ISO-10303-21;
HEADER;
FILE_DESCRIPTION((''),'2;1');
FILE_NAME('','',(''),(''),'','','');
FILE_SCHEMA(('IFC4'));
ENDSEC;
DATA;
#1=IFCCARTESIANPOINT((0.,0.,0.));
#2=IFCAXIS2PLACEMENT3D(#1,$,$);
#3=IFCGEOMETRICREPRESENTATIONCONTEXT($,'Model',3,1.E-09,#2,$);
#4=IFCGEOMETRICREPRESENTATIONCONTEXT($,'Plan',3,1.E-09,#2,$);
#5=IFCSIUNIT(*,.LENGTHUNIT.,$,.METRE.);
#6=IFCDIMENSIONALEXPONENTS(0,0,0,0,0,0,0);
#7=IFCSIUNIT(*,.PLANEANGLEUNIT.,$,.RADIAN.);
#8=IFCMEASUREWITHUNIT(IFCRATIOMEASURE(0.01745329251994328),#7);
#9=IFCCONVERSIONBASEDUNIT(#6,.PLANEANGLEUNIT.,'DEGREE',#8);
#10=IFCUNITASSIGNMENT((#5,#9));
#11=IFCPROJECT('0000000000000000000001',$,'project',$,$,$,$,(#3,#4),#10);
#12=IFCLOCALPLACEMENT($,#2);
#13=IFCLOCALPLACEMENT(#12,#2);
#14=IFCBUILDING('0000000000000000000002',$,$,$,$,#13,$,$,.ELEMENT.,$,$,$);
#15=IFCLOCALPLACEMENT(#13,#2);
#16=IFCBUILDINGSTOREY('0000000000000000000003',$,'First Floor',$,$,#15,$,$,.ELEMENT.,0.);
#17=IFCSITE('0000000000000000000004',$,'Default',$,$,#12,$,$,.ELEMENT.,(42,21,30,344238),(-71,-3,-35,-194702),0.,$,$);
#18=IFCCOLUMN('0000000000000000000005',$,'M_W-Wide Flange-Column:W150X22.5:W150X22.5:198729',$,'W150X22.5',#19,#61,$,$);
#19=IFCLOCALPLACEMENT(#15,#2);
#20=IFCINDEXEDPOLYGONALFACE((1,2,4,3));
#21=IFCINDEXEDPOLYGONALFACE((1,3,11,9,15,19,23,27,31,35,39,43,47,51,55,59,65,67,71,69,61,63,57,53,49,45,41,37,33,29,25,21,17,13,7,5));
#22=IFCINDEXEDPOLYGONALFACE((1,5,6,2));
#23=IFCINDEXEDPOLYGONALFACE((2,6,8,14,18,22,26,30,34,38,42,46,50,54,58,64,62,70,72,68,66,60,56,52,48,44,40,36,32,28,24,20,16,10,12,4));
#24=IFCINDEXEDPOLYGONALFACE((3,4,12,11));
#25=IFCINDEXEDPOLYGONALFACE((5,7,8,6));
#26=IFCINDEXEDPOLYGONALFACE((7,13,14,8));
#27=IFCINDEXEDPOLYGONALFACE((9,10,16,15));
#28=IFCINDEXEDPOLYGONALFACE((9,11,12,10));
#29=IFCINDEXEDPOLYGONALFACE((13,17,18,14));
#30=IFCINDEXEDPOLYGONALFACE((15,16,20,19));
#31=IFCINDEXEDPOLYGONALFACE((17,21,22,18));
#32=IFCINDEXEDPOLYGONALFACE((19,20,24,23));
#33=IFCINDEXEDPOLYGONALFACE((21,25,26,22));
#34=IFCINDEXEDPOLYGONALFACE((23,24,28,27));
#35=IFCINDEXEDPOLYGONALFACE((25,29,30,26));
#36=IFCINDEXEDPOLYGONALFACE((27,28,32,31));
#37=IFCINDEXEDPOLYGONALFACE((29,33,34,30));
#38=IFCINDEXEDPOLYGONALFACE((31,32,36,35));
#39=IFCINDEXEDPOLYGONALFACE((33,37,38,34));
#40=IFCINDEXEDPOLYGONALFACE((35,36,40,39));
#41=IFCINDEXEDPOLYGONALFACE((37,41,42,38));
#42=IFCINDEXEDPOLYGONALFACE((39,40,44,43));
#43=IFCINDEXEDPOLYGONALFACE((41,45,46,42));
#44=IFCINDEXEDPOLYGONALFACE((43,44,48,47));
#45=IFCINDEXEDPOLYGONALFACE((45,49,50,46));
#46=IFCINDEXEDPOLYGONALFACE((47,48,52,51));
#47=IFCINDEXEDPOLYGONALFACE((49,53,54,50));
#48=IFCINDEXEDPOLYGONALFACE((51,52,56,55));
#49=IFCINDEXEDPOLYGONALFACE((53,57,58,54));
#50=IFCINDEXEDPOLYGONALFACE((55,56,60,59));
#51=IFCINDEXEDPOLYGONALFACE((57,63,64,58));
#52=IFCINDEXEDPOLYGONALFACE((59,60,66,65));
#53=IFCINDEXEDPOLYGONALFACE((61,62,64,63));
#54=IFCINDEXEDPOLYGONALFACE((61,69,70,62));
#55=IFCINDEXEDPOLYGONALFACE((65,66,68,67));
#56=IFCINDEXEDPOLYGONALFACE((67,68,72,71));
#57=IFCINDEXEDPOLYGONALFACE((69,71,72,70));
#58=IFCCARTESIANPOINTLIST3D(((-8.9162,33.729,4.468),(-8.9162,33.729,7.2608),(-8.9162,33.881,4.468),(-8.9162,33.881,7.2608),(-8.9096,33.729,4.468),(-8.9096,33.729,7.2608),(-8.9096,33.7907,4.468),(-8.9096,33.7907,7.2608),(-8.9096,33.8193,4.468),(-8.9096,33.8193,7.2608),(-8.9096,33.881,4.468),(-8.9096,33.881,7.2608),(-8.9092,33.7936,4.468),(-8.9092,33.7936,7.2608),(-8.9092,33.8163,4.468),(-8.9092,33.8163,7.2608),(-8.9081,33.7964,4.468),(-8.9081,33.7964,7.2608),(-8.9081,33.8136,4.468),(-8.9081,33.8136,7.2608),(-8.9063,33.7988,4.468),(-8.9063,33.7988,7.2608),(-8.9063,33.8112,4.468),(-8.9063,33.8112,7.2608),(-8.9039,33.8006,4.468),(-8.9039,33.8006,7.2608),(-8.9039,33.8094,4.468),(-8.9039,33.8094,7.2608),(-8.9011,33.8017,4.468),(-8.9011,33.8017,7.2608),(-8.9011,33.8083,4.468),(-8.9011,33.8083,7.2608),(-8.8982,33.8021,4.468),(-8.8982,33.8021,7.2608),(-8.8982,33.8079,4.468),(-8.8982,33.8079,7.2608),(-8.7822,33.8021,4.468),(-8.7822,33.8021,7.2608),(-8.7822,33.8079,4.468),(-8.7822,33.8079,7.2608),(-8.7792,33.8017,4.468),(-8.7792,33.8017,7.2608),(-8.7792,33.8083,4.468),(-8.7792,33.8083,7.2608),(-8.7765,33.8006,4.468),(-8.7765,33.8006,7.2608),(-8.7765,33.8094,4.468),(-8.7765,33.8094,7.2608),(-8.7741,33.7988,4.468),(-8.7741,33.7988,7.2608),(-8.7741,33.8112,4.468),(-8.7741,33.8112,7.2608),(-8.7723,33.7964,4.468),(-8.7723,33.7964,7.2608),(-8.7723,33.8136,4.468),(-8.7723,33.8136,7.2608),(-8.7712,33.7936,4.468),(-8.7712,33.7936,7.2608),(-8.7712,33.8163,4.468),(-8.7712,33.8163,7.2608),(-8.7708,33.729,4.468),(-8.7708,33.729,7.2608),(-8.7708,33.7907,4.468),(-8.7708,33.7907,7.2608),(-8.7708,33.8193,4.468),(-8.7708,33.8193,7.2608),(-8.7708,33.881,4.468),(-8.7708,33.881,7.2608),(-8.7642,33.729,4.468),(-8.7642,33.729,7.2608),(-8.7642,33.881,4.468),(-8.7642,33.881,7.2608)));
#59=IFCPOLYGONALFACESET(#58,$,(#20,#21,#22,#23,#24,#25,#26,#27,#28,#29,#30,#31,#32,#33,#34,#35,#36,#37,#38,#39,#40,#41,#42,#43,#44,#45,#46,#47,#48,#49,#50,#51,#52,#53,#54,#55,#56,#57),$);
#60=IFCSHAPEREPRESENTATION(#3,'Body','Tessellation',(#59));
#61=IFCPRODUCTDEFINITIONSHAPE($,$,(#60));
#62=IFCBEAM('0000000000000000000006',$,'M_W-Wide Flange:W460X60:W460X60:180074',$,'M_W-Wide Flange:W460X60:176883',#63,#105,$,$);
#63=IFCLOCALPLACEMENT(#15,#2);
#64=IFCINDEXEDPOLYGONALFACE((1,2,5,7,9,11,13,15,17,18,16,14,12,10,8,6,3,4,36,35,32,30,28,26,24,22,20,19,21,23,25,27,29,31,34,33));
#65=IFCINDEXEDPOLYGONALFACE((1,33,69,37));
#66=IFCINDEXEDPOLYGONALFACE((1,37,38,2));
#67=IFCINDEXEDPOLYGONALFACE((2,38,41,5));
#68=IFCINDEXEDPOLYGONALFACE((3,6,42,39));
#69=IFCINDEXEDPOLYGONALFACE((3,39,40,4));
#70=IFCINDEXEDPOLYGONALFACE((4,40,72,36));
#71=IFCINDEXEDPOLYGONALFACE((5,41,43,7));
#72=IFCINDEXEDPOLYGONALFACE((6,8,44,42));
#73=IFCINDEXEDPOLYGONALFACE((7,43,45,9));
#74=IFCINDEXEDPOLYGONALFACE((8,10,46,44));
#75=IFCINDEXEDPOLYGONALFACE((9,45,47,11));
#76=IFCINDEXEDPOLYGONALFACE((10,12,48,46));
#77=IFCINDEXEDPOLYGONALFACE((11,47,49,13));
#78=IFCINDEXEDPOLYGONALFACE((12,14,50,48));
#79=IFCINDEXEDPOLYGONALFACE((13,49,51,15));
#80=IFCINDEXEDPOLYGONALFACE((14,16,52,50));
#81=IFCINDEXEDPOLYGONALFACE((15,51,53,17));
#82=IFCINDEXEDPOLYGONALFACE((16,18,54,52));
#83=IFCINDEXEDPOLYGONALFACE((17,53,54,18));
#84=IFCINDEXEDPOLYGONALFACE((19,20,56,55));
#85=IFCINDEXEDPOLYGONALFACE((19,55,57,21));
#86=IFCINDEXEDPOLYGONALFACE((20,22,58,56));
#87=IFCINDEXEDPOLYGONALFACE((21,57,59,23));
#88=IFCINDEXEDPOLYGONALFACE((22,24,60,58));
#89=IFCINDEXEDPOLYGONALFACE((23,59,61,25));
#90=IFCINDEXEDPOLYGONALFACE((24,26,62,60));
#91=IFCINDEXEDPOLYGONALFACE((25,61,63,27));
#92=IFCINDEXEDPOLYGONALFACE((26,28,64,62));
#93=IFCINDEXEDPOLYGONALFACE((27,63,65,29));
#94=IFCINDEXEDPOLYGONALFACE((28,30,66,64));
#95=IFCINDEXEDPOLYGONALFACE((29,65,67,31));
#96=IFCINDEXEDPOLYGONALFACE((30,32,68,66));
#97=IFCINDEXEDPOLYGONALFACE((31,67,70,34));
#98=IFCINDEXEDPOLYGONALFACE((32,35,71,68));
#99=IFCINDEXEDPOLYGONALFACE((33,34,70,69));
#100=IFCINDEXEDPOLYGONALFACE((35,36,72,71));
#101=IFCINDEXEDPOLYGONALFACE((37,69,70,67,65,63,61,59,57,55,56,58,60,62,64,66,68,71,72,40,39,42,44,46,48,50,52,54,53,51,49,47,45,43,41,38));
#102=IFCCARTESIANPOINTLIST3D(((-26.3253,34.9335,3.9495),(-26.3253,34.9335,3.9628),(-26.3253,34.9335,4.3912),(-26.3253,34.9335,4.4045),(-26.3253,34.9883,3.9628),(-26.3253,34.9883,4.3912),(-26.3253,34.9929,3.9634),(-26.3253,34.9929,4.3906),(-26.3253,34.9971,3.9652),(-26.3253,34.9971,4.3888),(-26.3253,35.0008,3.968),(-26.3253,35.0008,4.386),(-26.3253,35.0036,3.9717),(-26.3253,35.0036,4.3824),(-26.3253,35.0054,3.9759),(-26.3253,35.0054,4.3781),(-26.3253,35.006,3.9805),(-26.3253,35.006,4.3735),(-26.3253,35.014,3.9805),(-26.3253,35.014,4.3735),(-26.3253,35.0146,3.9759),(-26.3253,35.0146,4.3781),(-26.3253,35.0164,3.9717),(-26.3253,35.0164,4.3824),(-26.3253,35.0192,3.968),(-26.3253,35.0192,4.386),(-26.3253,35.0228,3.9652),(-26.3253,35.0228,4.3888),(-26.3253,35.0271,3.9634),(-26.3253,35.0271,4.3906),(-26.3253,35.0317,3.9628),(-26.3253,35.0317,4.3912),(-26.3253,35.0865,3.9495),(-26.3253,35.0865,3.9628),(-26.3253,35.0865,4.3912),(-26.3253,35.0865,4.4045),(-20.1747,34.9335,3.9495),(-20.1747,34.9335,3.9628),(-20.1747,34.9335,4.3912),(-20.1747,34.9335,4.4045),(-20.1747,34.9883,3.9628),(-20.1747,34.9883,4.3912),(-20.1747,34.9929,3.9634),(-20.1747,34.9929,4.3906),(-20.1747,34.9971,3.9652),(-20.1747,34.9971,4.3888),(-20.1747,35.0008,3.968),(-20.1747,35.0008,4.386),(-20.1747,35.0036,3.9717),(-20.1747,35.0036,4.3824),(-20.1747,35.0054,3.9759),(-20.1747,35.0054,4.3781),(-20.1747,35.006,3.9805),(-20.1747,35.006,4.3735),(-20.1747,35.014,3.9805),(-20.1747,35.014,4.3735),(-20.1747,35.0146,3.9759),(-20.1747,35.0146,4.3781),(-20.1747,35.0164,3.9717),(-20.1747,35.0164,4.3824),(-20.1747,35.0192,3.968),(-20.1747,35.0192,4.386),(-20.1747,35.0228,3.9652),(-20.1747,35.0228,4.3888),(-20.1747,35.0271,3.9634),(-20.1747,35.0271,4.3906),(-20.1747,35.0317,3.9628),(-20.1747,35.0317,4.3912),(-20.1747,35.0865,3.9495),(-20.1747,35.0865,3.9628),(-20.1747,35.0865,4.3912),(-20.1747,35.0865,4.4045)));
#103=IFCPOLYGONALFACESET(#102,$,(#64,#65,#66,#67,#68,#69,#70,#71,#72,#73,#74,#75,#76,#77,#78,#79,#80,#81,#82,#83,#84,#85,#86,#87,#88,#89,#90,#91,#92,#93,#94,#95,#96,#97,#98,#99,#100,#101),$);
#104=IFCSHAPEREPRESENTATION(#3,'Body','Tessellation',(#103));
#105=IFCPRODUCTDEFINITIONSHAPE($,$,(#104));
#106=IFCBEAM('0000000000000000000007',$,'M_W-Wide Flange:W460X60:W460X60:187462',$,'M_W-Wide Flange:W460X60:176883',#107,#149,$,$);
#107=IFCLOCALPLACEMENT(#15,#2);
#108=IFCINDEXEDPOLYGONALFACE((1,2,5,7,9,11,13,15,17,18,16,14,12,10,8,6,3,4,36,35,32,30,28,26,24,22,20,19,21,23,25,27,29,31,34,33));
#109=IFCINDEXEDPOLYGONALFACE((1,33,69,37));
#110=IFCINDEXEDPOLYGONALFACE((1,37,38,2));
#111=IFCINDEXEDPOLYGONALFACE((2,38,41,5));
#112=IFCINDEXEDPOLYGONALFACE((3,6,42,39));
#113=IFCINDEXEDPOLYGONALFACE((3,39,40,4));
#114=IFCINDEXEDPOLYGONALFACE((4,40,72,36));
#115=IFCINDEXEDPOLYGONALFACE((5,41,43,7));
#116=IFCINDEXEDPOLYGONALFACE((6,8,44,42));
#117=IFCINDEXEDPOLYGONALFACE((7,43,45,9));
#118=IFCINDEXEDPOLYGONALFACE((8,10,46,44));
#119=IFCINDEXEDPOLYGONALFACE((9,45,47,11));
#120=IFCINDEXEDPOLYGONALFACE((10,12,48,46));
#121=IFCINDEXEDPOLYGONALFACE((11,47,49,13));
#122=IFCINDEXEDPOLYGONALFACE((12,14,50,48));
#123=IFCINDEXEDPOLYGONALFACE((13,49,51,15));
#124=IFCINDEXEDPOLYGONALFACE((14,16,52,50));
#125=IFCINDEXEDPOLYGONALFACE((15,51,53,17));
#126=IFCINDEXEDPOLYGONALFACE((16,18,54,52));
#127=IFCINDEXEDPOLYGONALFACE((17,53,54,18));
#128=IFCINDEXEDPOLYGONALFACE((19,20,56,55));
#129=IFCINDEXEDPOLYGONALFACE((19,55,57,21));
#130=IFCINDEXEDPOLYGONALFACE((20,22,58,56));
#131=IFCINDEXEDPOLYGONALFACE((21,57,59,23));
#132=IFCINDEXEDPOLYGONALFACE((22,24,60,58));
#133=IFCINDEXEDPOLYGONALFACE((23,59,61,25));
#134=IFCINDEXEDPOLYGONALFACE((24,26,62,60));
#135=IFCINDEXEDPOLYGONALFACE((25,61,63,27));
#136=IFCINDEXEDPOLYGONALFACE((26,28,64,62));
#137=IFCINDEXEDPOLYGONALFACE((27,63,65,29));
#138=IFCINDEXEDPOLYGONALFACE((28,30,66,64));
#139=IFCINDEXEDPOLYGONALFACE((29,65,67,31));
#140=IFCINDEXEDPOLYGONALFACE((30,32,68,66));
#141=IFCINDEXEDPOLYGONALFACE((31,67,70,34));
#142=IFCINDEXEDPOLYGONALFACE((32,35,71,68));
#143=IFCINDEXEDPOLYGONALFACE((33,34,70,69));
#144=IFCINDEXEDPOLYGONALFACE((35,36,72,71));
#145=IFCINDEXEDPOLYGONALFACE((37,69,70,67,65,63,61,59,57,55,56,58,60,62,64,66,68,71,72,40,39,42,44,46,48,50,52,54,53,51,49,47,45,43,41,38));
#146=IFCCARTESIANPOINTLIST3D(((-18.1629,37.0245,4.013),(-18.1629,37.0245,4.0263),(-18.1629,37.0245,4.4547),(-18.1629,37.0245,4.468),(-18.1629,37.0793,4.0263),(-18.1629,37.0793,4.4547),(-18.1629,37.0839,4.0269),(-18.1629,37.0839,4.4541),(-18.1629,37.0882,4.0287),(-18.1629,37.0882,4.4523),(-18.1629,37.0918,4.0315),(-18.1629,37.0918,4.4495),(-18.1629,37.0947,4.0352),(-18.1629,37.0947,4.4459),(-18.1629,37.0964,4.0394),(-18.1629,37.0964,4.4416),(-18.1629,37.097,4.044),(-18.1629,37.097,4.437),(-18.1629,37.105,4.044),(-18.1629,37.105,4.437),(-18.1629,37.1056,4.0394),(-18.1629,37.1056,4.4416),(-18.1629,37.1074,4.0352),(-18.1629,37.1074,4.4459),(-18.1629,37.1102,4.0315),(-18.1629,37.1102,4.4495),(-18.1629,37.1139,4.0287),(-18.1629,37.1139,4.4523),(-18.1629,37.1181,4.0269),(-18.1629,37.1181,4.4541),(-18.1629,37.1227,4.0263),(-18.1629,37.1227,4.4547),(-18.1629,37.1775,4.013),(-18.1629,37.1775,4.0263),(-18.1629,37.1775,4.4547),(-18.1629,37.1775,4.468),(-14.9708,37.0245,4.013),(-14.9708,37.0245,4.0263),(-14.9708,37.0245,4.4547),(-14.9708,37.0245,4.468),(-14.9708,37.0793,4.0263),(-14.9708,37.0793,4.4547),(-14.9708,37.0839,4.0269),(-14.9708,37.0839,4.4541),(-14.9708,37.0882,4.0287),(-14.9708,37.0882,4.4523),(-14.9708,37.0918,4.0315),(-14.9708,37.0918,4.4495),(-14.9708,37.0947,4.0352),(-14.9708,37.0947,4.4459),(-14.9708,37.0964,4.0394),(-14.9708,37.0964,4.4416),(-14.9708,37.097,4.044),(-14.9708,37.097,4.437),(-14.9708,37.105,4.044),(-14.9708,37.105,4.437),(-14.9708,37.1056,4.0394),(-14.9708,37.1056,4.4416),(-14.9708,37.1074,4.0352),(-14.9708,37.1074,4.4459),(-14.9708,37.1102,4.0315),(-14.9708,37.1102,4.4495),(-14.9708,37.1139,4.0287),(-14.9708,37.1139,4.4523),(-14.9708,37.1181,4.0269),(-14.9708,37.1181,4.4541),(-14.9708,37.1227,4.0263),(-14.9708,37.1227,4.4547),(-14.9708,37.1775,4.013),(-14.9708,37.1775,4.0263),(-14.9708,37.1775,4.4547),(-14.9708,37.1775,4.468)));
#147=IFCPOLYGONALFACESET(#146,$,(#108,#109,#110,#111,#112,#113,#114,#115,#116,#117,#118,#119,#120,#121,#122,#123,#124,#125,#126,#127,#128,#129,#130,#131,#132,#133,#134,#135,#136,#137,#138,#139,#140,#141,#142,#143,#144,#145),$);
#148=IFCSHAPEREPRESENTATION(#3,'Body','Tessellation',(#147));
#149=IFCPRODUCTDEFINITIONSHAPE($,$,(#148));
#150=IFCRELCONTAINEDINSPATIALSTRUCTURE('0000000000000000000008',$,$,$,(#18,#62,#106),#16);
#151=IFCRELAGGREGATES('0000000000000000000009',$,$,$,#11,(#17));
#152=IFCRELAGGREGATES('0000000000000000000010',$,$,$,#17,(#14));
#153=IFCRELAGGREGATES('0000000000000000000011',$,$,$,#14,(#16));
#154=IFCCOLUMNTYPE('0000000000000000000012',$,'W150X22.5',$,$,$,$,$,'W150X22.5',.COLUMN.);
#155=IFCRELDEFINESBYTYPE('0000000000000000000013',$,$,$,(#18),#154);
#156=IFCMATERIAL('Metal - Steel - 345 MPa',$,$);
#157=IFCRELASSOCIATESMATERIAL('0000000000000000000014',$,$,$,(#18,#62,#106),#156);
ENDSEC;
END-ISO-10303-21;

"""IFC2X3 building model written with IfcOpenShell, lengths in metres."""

from ifc_helpers import new_model, entity, si_unit, converted_unit, frame, frame_2d, origin, place, context, project, spatial, polyline, circle_curve, parameter, trimmed, segment, composite_curve, outline, extrude, source, transform, mapped, material, type_object, type_shapes, element, save


model = new_model("IFC2X3")

# Units and contexts
model_context = context("Model", 3, precision=1e-09, world=origin())
plan_context = context("Plan", 3, precision=1e-09, world=origin())
ifc_project = project(units=[si_unit("LENGTHUNIT", "METRE"), converted_unit("PLANEANGLEUNIT", "DEGREE", entity("IfcRatioMeasure", 0.01745329251994328), si_unit("PLANEANGLEUNIT", "RADIAN"), dimensions=[0, 0, 0, 0, 0, 0, 0])], contexts=[model_context, plan_context])

# Site, building, storey
site_placement = place(None, origin())
site = spatial("IfcSite", under=ifc_project, at=site_placement, Name="Default", CompositionType="ELEMENT", RefLatitude=(42, 21, 30, 344238), RefLongitude=(-71, -3, -35, -194702), RefElevation=0.0)
building_placement = place(site_placement, origin())
building = spatial("IfcBuilding", under=site, at=building_placement, CompositionType="ELEMENT")
storey_placement = place(building_placement, origin())
storey = spatial("IfcBuildingStorey", under=building, at=storey_placement, Name="First Floor", CompositionType="ELEMENT", Elevation=0.0)

# Column
ifc_material = material(Name="Metal - Steel - 345 MPa")
column_type = type_object("IfcColumnType", Name="W150X22.5", ElementType="W150X22.5", PredefinedType="COLUMN")
shared_shape = source(origin(), model_context, "Body", "SweptSolid", [
    extrude(outline(composite_curve([segment(polyline([(-0.076, -0.076), (0.076, -0.076)]), True, "CONTINUOUS"), segment(polyline([(0.076, -0.076), (0.076, -0.0694)]), True, "CONTINUOUS"), segment(polyline([(0.076, -0.0694), (0.0143, -0.0694)]), True, "CONTINUOUS"), segment(trimmed(circle_curve(frame_2d((0.0143, -0.058), x_axis=(-1.0, 0.0)), 0.0114), [parameter(0.0)], [parameter(90.0)], True, "PARAMETER"), False, "CONTINUOUS"), segment(polyline([(0.0029, -0.058), (0.0029, 0.058)]), True, "CONTINUOUS"), segment(trimmed(circle_curve(frame_2d((0.0143, 0.058), x_axis=(-1.0, 0.0)), 0.0114), [parameter(270.0)], [parameter(0.0)], True, "PARAMETER"), False, "CONTINUOUS"), segment(polyline([(0.0143, 0.0694), (0.076, 0.0694)]), True, "CONTINUOUS"), segment(polyline([(0.076, 0.0694), (0.076, 0.076)]), True, "CONTINUOUS"), segment(polyline([(0.076, 0.076), (-0.076, 0.076)]), True, "CONTINUOUS"), segment(polyline([(-0.076, 0.076), (-0.076, 0.0694)]), True, "CONTINUOUS"), segment(polyline([(-0.076, 0.0694), (-0.0143, 0.0694)]), True, "CONTINUOUS"), segment(trimmed(circle_curve(frame_2d((-0.0143, 0.058), x_axis=(-1.0, 0.0)), 0.0114), [parameter(180.0)], [parameter(270.0)], True, "PARAMETER"), False, "CONTINUOUS"), segment(polyline([(-0.0029, 0.058), (-0.0029, -0.058)]), True, "CONTINUOUS"), segment(trimmed(circle_curve(frame_2d((-0.0143, -0.058), x_axis=(-1.0, 0.0)), 0.0114), [parameter(90.0)], [parameter(180.0)], True, "PARAMETER"), False, "CONTINUOUS"), segment(polyline([(-0.0143, -0.0694), (-0.076, -0.0694)]), True, "CONTINUOUS"), segment(polyline([(-0.076, -0.0694), (-0.076, -0.076)]), True, "CONTINUOUS")], self_intersect=False)), frame((0.0, 0.0, 4.468), z_axis=(0.0, 0.0, 1.0), x_axis=(-1.0, 0.0, 0.0)), (0.0, 0.0, 1.0), 2.7928),
])
type_shapes(column_type, [shared_shape])
column_placement = place(storey_placement, frame((-8.8402, 33.805, 0.0), z_axis=(0.0, 0.0, 1.0), x_axis=(0.0, 1.0, 0.0)))
element("IfcColumn", 1, at=column_placement, inside=storey, type_object=column_type, material=ifc_material, Name="M_W-Wide Flange-Column:W150X22.5:W150X22.5:198729", ObjectType="W150X22.5", context=model_context, shape_type="MappedRepresentation", body=[
    mapped(shared_shape, transform((0.0, 0.0, 0.0), scale=1.0)),
])

# Beams
beam_1_placement = place(storey_placement, frame((-20.0579, 35.01, 4.4045), z_axis=(0.0, 0.0, 1.0), x_axis=(0.0, 1.0, 0.0)))
element("IfcBeam", 2, at=beam_1_placement, inside=storey, material=ifc_material, Name="M_W-Wide Flange:W460X60:W460X60:180074", ObjectType="M_W-Wide Flange:W460X60:176883", context=model_context, shape_type="SweptSolid", body=[
    extrude(outline(composite_curve([segment(polyline([(0.2142, -0.0765), (0.2275, -0.0765)]), True, "CONTINUOUS"), segment(polyline([(0.2275, -0.0765), (0.2275, 0.0765)]), True, "CONTINUOUS"), segment(polyline([(0.2275, 0.0765), (0.2142, 0.0765)]), True, "CONTINUOUS"), segment(polyline([(0.2142, 0.0765), (0.2142, 0.0217)]), True, "CONTINUOUS"), segment(trimmed(circle_curve(frame_2d((0.1965, 0.0217), x_axis=(1.0, 0.0)), 0.0177), [parameter(270.0)], [parameter(360.0)], True, "PARAMETER"), False, "CONTINUOUS"), segment(polyline([(0.1965, 0.004), (-0.1965, 0.004)]), True, "CONTINUOUS"), segment(trimmed(circle_curve(frame_2d((-0.1965, 0.0217), x_axis=(0.0, -1.0)), 0.0177), [parameter(270.0)], [parameter(360.0)], True, "PARAMETER"), False, "CONTINUOUS"), segment(polyline([(-0.2142, 0.0217), (-0.2142, 0.0765)]), True, "CONTINUOUS"), segment(polyline([(-0.2142, 0.0765), (-0.2275, 0.0765)]), True, "CONTINUOUS"), segment(polyline([(-0.2275, 0.0765), (-0.2275, -0.0765)]), True, "CONTINUOUS"), segment(polyline([(-0.2275, -0.0765), (-0.2142, -0.0765)]), True, "CONTINUOUS"), segment(polyline([(-0.2142, -0.0765), (-0.2142, -0.0217)]), True, "CONTINUOUS"), segment(trimmed(circle_curve(frame_2d((-0.1965, -0.0217), x_axis=(-1.0, 0.0)), 0.0177), [parameter(270.0)], [parameter(360.0)], True, "PARAMETER"), False, "CONTINUOUS"), segment(polyline([(-0.1965, -0.004), (0.1965, -0.004)]), True, "CONTINUOUS"), segment(trimmed(circle_curve(frame_2d((0.1965, -0.0217), x_axis=(0.0, 1.0)), 0.0177), [parameter(270.0)], [parameter(0.0)], True, "PARAMETER"), False, "CONTINUOUS"), segment(polyline([(0.2142, -0.0217), (0.2142, -0.0765)]), True, "CONTINUOUS")], self_intersect=False)), frame((0.0, 6.2674, -0.2275), z_axis=(0.0, -1.0, 0.0), x_axis=(0.0, 0.0, -1.0)), (0.0, 0.0, 1.0), 6.1506),
])
beam_2_placement = place(storey_placement, frame((-17.9301, 37.101, 4.468), z_axis=(0.0, 0.0, 1.0), x_axis=(0.0, -1.0, 0.0)))
element("IfcBeam", 3, at=beam_2_placement, inside=storey, material=ifc_material, Name="M_W-Wide Flange:W460X60:W460X60:187462", ObjectType="M_W-Wide Flange:W460X60:176883", context=model_context, shape_type="SweptSolid", body=[
    extrude(outline(composite_curve([segment(polyline([(-0.0765, -0.2142), (-0.0765, -0.2275)]), True, "CONTINUOUS"), segment(polyline([(-0.0765, -0.2275), (0.0765, -0.2275)]), True, "CONTINUOUS"), segment(polyline([(0.0765, -0.2275), (0.0765, -0.2142)]), True, "CONTINUOUS"), segment(polyline([(0.0765, -0.2142), (0.0217, -0.2142)]), True, "CONTINUOUS"), segment(trimmed(circle_curve(frame_2d((0.0217, -0.1965), x_axis=(1.0, 0.0)), 0.0177), [parameter(180.0)], [parameter(270.0)], True, "PARAMETER"), False, "CONTINUOUS"), segment(polyline([(0.004, -0.1965), (0.004, 0.1965)]), True, "CONTINUOUS"), segment(trimmed(circle_curve(frame_2d((0.0217, 0.1965), x_axis=(1.0, 0.0)), 0.0177), [parameter(90.0)], [parameter(180.0)], True, "PARAMETER"), False, "CONTINUOUS"), segment(polyline([(0.0217, 0.2142), (0.0765, 0.2142)]), True, "CONTINUOUS"), segment(polyline([(0.0765, 0.2142), (0.0765, 0.2275)]), True, "CONTINUOUS"), segment(polyline([(0.0765, 0.2275), (-0.0765, 0.2275)]), True, "CONTINUOUS"), segment(polyline([(-0.0765, 0.2275), (-0.0765, 0.2142)]), True, "CONTINUOUS"), segment(polyline([(-0.0765, 0.2142), (-0.0217, 0.2142)]), True, "CONTINUOUS"), segment(trimmed(circle_curve(frame_2d((-0.0217, 0.1965), x_axis=(1.0, 0.0)), 0.0177), [parameter(360.0)], [parameter(90.0)], True, "PARAMETER"), False, "CONTINUOUS"), segment(polyline([(-0.004, 0.1965), (-0.004, -0.1965)]), True, "CONTINUOUS"), segment(trimmed(circle_curve(frame_2d((-0.0217, -0.1965), x_axis=(1.0, 0.0)), 0.0177), [parameter(270.0)], [parameter(0.0)], True, "PARAMETER"), False, "CONTINUOUS"), segment(polyline([(-0.0217, -0.2142), (-0.0765, -0.2142)]), True, "CONTINUOUS")], self_intersect=False)), frame((0.0, -0.2327, -0.2275), z_axis=(0.0, -1.0, 0.0), x_axis=(1.0, 0.0, 0.0)), (0.0, 0.0, -1.0), 3.1921),
])

save(model, "model.ifc")
